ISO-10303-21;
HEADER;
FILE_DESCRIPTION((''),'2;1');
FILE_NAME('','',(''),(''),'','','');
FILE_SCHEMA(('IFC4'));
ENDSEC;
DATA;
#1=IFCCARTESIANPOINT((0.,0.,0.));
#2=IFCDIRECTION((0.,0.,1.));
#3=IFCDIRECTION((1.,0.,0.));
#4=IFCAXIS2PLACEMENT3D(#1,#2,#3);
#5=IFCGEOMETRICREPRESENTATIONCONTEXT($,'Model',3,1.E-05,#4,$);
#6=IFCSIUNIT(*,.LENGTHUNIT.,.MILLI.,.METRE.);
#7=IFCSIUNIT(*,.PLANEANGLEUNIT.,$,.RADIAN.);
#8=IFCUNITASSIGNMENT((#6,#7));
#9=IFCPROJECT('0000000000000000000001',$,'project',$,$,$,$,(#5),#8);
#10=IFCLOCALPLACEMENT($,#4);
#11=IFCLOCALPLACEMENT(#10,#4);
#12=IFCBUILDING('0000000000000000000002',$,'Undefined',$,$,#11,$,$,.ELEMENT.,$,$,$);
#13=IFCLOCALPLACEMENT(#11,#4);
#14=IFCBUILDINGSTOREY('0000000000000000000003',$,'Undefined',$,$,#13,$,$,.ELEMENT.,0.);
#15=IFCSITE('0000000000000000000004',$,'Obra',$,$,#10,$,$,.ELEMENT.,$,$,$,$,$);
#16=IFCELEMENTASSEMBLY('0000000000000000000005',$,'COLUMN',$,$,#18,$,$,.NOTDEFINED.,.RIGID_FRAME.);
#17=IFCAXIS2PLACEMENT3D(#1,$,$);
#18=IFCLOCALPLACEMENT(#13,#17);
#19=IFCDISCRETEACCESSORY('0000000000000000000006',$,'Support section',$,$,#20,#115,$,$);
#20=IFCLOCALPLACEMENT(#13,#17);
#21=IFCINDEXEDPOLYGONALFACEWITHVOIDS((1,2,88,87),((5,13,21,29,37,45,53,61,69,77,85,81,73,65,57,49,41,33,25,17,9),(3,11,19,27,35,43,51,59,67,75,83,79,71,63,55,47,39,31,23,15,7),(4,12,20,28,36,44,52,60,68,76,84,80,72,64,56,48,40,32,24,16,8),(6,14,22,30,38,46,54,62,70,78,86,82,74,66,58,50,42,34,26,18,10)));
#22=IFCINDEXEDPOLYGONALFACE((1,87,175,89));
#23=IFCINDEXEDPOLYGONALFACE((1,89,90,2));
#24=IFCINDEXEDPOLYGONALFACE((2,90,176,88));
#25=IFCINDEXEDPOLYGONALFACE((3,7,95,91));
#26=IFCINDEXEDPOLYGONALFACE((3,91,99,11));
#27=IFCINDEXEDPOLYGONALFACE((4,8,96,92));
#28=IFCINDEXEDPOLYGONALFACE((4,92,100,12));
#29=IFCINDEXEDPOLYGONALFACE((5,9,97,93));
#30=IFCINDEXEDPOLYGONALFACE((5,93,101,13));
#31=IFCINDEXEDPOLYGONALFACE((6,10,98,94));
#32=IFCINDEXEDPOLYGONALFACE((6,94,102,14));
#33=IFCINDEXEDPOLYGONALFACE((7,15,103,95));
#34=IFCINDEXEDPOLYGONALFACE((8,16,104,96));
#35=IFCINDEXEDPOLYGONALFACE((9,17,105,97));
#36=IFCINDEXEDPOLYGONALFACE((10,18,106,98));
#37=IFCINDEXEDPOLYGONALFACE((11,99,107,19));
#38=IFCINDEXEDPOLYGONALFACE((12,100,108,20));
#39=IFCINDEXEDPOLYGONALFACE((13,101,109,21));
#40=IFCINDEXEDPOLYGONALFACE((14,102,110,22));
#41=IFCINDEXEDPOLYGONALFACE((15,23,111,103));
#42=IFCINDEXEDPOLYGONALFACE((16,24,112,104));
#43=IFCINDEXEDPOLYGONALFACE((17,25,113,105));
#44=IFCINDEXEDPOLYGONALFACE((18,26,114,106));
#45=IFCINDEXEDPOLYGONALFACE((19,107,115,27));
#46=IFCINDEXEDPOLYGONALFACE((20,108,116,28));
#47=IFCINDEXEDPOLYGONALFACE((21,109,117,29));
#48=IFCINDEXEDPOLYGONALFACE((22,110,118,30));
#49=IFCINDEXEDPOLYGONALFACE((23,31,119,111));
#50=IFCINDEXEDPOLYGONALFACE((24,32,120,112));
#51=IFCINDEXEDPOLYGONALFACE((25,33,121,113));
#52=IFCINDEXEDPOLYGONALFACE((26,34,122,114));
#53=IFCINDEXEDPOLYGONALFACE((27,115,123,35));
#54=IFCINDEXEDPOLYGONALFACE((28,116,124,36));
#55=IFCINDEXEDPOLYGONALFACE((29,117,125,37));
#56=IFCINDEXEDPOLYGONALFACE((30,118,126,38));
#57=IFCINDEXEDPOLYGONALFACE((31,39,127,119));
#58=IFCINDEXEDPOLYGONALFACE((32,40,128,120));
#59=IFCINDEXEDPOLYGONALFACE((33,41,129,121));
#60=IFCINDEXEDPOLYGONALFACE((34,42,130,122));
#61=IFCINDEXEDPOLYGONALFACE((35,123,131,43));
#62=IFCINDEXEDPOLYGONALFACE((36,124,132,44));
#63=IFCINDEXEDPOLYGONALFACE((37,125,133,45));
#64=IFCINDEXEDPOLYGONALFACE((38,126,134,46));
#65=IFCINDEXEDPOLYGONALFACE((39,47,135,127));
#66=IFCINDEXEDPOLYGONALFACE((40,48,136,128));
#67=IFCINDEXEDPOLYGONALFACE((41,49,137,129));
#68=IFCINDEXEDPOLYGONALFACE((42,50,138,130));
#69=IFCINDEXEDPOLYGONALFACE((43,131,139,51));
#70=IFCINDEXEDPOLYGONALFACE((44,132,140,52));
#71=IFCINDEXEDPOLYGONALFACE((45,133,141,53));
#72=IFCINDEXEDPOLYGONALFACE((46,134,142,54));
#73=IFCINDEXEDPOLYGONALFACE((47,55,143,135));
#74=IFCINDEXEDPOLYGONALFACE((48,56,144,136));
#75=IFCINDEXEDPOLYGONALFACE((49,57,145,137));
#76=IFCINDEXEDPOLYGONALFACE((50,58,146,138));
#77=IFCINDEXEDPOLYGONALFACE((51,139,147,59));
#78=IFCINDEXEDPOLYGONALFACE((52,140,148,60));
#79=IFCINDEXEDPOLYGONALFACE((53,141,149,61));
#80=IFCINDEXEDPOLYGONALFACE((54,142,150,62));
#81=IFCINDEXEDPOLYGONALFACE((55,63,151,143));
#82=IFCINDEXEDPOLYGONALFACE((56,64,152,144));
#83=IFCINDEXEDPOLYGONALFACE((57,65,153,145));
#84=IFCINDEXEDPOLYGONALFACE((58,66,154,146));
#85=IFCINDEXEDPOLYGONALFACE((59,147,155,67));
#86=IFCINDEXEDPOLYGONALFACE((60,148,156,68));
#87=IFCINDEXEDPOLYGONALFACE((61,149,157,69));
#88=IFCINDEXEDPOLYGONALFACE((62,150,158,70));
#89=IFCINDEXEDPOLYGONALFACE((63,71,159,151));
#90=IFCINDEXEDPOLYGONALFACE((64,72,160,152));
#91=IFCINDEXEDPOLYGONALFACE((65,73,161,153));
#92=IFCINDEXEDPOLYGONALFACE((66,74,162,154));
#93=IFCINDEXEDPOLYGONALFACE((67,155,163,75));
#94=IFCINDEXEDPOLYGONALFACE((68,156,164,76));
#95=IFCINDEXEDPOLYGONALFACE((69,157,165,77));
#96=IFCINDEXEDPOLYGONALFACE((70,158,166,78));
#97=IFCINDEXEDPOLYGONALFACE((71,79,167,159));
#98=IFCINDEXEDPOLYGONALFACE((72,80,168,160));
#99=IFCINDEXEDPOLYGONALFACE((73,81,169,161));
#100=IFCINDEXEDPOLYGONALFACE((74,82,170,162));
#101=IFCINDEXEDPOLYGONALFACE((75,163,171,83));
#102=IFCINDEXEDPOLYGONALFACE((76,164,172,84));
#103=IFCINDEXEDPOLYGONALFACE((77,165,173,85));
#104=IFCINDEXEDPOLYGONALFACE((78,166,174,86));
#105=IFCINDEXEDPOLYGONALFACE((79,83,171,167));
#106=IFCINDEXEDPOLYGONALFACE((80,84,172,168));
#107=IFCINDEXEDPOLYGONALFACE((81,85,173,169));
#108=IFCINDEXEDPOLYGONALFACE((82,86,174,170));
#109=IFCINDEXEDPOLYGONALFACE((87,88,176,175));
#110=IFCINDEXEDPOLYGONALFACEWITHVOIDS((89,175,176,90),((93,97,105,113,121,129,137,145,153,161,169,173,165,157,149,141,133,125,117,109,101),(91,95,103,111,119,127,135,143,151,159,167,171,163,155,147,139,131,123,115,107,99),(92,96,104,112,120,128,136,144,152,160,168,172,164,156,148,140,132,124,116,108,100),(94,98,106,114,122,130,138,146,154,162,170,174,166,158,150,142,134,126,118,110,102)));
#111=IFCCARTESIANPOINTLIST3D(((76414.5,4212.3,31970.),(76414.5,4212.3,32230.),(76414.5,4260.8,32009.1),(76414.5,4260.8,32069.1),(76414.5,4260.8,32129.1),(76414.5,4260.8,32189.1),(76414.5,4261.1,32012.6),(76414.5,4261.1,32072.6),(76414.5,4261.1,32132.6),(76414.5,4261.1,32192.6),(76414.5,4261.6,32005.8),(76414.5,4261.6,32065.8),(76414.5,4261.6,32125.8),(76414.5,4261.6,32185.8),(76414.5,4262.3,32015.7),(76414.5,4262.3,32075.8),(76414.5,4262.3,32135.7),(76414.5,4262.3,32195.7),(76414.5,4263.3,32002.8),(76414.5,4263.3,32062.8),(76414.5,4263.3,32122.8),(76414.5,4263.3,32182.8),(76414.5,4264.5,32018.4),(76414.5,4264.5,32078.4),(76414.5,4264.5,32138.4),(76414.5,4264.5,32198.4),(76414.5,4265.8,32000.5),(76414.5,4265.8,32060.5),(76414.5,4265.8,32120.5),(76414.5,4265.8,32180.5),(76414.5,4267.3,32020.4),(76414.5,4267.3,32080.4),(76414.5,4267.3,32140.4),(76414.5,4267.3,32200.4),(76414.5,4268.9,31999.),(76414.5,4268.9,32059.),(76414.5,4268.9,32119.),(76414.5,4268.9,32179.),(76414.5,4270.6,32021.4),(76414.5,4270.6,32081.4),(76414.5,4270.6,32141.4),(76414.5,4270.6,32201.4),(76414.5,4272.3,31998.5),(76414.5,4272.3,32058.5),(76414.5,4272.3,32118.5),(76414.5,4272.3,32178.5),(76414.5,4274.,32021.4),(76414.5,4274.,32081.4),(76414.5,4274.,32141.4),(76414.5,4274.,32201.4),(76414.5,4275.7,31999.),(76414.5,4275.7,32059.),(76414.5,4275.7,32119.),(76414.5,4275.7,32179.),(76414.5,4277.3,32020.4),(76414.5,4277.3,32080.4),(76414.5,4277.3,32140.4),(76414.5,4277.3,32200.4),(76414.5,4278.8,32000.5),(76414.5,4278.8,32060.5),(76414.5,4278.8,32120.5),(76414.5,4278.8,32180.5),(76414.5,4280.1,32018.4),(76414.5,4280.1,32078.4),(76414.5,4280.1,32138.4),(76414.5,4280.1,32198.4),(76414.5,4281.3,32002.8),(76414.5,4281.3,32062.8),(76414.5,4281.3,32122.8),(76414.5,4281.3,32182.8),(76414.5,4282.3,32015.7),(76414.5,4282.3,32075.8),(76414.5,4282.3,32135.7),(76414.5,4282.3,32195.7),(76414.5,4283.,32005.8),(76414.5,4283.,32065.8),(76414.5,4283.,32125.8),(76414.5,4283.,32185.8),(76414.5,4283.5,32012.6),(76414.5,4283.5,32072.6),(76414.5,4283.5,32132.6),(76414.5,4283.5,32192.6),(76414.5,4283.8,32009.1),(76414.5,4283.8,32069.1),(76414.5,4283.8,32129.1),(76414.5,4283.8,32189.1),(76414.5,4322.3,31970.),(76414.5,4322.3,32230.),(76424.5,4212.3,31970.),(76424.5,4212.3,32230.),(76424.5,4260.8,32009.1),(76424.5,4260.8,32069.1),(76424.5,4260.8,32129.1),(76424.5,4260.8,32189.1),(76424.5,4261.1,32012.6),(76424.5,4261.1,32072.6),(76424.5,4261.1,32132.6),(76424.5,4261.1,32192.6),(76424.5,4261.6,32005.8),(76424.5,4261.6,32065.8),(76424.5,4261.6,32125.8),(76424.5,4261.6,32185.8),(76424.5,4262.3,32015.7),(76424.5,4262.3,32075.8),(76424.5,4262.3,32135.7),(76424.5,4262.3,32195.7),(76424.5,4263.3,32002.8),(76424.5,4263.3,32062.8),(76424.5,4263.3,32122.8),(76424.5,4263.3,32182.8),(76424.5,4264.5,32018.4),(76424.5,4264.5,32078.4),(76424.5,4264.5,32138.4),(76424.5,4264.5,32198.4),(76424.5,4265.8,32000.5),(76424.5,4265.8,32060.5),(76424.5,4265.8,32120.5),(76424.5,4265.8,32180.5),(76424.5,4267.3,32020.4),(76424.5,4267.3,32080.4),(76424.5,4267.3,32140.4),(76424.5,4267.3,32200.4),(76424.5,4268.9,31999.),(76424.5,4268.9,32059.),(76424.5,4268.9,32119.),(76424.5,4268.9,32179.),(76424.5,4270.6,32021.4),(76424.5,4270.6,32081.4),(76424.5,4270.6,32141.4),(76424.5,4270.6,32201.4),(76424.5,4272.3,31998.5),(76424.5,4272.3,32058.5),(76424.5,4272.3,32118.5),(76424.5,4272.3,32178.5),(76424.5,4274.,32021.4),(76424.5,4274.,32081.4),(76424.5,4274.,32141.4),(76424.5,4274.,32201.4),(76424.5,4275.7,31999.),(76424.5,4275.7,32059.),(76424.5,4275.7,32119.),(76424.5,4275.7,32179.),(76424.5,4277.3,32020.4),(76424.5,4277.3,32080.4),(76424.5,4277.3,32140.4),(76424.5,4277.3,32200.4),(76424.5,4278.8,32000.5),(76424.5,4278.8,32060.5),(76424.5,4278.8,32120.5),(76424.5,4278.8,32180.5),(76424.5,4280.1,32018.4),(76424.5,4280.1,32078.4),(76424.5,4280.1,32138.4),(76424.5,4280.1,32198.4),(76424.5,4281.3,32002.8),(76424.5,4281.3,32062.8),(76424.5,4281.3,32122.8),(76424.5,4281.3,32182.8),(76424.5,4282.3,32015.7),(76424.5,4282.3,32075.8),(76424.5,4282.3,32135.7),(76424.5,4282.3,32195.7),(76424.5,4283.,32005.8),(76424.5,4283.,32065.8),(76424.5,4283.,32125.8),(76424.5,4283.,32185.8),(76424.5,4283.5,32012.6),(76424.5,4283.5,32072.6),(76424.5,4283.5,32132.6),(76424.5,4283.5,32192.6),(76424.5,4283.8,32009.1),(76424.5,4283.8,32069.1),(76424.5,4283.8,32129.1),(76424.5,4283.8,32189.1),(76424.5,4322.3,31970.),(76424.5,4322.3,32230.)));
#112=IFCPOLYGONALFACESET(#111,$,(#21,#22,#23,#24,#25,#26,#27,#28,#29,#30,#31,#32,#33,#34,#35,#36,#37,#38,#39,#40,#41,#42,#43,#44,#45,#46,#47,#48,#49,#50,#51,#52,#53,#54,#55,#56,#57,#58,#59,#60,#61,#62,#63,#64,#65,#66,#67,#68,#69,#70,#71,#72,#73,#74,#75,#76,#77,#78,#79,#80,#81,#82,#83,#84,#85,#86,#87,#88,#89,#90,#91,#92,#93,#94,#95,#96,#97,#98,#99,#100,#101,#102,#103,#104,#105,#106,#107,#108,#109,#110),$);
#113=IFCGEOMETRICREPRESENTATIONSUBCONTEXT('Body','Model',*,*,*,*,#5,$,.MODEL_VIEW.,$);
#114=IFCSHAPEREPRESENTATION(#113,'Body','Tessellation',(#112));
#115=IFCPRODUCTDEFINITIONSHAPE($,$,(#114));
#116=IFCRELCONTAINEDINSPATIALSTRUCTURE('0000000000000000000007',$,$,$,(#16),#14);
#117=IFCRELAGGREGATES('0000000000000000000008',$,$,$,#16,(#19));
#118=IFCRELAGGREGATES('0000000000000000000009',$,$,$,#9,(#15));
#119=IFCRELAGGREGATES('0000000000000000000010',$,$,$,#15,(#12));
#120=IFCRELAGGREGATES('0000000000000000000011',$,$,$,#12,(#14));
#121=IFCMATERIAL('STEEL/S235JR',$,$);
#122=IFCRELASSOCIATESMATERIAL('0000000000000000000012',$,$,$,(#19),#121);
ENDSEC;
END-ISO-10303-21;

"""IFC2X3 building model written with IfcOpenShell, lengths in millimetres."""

from ifc_helpers import new_model, si_unit, frame, origin_with_axes, origin_2d_with_axis, place, context, subcontext, project, spatial, rectangle, circle, extrude, source, transform, mapped, material, element, aggregate, save


model = new_model("IFC2X3")

# Units and contexts
model_context = context("Model", 3, precision=1e-05, world=origin_with_axes())
body_context = subcontext(model_context, "Body", "Model", "MODEL_VIEW")
ifc_project = project(units=[si_unit("LENGTHUNIT", "METRE", prefix="MILLI"), si_unit("PLANEANGLEUNIT", "RADIAN")], contexts=[model_context])

# Site, building, storey
site_placement = place(None, origin_with_axes())
site = spatial("IfcSite", under=ifc_project, at=site_placement, Name="Obra", CompositionType="ELEMENT")
building_placement = place(site_placement, origin_with_axes())
building = spatial("IfcBuilding", under=site, at=building_placement, Name="Undefined", CompositionType="ELEMENT")
storey_placement = place(building_placement, origin_with_axes())
storey = spatial("IfcBuildingStorey", under=building, at=storey_placement, Name="Undefined", CompositionType="ELEMENT", Elevation=0.0)

# Shared definitions
ifc_material_1 = material(Name="STEEL/S235JR")

# Element assembly, discrete accessory, opening
assembly_1_placement = place(storey_placement, origin_with_axes())
assembly_1 = element("IfcElementAssembly", 1, at=assembly_1_placement, inside=storey, Name="COLUMN", AssemblyPlace="NOTDEFINED", PredefinedType="RIGID_FRAME")
shared_shape_1 = source(origin_with_axes(), body_context, "Body", "SweptSolid", [
    extrude(circle(Radius=11.5, at=origin_2d_with_axis()), frame((0.0, -14.4, 0.0), z_axis=(0.0, 1.0, 0.0), x_axis=(1.0, 0.0, 0.0)), (0.0, 0.0, 1.0), 10.2),
])
discrete_accessory_1_placement = place(assembly_1_placement, frame((76419.5, 4267.3, 31970.0), z_axis=(0.0, 0.0, 1.0), x_axis=(0.0, -1.0, 0.0)))
discrete_accessory_1 = element("IfcDiscreteAccessory", 2, at=discrete_accessory_1_placement, material=ifc_material_1, Name="Support section", context=body_context, shape_type="SweptSolid", body=[
    extrude(rectangle(XDim=10.0, YDim=110.0, at=origin_2d_with_axis()), frame((0.0, 0.0, 260.0), z_axis=(0.0, 0.0, -1.0), x_axis=(0.0, 1.0, 0.0)), (0.0, 0.0, 1.0), 260.0),
])
opening_1_placement = place(assembly_1_placement, frame((76410.2, 4222.3, 32300.0), z_axis=(0.0, 1.0, 0.0), x_axis=(0.0, 0.0, -1.0)))
element("IfcOpeningElement", 3, at=opening_1_placement, cuts=discrete_accessory_1, ObjectType="Opening", context=body_context, shape_type="MappedRepresentation", body=[
    mapped(shared_shape_1, transform((110.0, 0.0, 50.0))),
    mapped(shared_shape_1, transform((170.0, 0.0, 50.0))),
    mapped(shared_shape_1, transform((230.0, 0.0, 50.0))),
    mapped(shared_shape_1, transform((290.0, 0.0, 50.0))),
])

aggregate(assembly_1, [discrete_accessory_1])

save(model, "model.ifc")
